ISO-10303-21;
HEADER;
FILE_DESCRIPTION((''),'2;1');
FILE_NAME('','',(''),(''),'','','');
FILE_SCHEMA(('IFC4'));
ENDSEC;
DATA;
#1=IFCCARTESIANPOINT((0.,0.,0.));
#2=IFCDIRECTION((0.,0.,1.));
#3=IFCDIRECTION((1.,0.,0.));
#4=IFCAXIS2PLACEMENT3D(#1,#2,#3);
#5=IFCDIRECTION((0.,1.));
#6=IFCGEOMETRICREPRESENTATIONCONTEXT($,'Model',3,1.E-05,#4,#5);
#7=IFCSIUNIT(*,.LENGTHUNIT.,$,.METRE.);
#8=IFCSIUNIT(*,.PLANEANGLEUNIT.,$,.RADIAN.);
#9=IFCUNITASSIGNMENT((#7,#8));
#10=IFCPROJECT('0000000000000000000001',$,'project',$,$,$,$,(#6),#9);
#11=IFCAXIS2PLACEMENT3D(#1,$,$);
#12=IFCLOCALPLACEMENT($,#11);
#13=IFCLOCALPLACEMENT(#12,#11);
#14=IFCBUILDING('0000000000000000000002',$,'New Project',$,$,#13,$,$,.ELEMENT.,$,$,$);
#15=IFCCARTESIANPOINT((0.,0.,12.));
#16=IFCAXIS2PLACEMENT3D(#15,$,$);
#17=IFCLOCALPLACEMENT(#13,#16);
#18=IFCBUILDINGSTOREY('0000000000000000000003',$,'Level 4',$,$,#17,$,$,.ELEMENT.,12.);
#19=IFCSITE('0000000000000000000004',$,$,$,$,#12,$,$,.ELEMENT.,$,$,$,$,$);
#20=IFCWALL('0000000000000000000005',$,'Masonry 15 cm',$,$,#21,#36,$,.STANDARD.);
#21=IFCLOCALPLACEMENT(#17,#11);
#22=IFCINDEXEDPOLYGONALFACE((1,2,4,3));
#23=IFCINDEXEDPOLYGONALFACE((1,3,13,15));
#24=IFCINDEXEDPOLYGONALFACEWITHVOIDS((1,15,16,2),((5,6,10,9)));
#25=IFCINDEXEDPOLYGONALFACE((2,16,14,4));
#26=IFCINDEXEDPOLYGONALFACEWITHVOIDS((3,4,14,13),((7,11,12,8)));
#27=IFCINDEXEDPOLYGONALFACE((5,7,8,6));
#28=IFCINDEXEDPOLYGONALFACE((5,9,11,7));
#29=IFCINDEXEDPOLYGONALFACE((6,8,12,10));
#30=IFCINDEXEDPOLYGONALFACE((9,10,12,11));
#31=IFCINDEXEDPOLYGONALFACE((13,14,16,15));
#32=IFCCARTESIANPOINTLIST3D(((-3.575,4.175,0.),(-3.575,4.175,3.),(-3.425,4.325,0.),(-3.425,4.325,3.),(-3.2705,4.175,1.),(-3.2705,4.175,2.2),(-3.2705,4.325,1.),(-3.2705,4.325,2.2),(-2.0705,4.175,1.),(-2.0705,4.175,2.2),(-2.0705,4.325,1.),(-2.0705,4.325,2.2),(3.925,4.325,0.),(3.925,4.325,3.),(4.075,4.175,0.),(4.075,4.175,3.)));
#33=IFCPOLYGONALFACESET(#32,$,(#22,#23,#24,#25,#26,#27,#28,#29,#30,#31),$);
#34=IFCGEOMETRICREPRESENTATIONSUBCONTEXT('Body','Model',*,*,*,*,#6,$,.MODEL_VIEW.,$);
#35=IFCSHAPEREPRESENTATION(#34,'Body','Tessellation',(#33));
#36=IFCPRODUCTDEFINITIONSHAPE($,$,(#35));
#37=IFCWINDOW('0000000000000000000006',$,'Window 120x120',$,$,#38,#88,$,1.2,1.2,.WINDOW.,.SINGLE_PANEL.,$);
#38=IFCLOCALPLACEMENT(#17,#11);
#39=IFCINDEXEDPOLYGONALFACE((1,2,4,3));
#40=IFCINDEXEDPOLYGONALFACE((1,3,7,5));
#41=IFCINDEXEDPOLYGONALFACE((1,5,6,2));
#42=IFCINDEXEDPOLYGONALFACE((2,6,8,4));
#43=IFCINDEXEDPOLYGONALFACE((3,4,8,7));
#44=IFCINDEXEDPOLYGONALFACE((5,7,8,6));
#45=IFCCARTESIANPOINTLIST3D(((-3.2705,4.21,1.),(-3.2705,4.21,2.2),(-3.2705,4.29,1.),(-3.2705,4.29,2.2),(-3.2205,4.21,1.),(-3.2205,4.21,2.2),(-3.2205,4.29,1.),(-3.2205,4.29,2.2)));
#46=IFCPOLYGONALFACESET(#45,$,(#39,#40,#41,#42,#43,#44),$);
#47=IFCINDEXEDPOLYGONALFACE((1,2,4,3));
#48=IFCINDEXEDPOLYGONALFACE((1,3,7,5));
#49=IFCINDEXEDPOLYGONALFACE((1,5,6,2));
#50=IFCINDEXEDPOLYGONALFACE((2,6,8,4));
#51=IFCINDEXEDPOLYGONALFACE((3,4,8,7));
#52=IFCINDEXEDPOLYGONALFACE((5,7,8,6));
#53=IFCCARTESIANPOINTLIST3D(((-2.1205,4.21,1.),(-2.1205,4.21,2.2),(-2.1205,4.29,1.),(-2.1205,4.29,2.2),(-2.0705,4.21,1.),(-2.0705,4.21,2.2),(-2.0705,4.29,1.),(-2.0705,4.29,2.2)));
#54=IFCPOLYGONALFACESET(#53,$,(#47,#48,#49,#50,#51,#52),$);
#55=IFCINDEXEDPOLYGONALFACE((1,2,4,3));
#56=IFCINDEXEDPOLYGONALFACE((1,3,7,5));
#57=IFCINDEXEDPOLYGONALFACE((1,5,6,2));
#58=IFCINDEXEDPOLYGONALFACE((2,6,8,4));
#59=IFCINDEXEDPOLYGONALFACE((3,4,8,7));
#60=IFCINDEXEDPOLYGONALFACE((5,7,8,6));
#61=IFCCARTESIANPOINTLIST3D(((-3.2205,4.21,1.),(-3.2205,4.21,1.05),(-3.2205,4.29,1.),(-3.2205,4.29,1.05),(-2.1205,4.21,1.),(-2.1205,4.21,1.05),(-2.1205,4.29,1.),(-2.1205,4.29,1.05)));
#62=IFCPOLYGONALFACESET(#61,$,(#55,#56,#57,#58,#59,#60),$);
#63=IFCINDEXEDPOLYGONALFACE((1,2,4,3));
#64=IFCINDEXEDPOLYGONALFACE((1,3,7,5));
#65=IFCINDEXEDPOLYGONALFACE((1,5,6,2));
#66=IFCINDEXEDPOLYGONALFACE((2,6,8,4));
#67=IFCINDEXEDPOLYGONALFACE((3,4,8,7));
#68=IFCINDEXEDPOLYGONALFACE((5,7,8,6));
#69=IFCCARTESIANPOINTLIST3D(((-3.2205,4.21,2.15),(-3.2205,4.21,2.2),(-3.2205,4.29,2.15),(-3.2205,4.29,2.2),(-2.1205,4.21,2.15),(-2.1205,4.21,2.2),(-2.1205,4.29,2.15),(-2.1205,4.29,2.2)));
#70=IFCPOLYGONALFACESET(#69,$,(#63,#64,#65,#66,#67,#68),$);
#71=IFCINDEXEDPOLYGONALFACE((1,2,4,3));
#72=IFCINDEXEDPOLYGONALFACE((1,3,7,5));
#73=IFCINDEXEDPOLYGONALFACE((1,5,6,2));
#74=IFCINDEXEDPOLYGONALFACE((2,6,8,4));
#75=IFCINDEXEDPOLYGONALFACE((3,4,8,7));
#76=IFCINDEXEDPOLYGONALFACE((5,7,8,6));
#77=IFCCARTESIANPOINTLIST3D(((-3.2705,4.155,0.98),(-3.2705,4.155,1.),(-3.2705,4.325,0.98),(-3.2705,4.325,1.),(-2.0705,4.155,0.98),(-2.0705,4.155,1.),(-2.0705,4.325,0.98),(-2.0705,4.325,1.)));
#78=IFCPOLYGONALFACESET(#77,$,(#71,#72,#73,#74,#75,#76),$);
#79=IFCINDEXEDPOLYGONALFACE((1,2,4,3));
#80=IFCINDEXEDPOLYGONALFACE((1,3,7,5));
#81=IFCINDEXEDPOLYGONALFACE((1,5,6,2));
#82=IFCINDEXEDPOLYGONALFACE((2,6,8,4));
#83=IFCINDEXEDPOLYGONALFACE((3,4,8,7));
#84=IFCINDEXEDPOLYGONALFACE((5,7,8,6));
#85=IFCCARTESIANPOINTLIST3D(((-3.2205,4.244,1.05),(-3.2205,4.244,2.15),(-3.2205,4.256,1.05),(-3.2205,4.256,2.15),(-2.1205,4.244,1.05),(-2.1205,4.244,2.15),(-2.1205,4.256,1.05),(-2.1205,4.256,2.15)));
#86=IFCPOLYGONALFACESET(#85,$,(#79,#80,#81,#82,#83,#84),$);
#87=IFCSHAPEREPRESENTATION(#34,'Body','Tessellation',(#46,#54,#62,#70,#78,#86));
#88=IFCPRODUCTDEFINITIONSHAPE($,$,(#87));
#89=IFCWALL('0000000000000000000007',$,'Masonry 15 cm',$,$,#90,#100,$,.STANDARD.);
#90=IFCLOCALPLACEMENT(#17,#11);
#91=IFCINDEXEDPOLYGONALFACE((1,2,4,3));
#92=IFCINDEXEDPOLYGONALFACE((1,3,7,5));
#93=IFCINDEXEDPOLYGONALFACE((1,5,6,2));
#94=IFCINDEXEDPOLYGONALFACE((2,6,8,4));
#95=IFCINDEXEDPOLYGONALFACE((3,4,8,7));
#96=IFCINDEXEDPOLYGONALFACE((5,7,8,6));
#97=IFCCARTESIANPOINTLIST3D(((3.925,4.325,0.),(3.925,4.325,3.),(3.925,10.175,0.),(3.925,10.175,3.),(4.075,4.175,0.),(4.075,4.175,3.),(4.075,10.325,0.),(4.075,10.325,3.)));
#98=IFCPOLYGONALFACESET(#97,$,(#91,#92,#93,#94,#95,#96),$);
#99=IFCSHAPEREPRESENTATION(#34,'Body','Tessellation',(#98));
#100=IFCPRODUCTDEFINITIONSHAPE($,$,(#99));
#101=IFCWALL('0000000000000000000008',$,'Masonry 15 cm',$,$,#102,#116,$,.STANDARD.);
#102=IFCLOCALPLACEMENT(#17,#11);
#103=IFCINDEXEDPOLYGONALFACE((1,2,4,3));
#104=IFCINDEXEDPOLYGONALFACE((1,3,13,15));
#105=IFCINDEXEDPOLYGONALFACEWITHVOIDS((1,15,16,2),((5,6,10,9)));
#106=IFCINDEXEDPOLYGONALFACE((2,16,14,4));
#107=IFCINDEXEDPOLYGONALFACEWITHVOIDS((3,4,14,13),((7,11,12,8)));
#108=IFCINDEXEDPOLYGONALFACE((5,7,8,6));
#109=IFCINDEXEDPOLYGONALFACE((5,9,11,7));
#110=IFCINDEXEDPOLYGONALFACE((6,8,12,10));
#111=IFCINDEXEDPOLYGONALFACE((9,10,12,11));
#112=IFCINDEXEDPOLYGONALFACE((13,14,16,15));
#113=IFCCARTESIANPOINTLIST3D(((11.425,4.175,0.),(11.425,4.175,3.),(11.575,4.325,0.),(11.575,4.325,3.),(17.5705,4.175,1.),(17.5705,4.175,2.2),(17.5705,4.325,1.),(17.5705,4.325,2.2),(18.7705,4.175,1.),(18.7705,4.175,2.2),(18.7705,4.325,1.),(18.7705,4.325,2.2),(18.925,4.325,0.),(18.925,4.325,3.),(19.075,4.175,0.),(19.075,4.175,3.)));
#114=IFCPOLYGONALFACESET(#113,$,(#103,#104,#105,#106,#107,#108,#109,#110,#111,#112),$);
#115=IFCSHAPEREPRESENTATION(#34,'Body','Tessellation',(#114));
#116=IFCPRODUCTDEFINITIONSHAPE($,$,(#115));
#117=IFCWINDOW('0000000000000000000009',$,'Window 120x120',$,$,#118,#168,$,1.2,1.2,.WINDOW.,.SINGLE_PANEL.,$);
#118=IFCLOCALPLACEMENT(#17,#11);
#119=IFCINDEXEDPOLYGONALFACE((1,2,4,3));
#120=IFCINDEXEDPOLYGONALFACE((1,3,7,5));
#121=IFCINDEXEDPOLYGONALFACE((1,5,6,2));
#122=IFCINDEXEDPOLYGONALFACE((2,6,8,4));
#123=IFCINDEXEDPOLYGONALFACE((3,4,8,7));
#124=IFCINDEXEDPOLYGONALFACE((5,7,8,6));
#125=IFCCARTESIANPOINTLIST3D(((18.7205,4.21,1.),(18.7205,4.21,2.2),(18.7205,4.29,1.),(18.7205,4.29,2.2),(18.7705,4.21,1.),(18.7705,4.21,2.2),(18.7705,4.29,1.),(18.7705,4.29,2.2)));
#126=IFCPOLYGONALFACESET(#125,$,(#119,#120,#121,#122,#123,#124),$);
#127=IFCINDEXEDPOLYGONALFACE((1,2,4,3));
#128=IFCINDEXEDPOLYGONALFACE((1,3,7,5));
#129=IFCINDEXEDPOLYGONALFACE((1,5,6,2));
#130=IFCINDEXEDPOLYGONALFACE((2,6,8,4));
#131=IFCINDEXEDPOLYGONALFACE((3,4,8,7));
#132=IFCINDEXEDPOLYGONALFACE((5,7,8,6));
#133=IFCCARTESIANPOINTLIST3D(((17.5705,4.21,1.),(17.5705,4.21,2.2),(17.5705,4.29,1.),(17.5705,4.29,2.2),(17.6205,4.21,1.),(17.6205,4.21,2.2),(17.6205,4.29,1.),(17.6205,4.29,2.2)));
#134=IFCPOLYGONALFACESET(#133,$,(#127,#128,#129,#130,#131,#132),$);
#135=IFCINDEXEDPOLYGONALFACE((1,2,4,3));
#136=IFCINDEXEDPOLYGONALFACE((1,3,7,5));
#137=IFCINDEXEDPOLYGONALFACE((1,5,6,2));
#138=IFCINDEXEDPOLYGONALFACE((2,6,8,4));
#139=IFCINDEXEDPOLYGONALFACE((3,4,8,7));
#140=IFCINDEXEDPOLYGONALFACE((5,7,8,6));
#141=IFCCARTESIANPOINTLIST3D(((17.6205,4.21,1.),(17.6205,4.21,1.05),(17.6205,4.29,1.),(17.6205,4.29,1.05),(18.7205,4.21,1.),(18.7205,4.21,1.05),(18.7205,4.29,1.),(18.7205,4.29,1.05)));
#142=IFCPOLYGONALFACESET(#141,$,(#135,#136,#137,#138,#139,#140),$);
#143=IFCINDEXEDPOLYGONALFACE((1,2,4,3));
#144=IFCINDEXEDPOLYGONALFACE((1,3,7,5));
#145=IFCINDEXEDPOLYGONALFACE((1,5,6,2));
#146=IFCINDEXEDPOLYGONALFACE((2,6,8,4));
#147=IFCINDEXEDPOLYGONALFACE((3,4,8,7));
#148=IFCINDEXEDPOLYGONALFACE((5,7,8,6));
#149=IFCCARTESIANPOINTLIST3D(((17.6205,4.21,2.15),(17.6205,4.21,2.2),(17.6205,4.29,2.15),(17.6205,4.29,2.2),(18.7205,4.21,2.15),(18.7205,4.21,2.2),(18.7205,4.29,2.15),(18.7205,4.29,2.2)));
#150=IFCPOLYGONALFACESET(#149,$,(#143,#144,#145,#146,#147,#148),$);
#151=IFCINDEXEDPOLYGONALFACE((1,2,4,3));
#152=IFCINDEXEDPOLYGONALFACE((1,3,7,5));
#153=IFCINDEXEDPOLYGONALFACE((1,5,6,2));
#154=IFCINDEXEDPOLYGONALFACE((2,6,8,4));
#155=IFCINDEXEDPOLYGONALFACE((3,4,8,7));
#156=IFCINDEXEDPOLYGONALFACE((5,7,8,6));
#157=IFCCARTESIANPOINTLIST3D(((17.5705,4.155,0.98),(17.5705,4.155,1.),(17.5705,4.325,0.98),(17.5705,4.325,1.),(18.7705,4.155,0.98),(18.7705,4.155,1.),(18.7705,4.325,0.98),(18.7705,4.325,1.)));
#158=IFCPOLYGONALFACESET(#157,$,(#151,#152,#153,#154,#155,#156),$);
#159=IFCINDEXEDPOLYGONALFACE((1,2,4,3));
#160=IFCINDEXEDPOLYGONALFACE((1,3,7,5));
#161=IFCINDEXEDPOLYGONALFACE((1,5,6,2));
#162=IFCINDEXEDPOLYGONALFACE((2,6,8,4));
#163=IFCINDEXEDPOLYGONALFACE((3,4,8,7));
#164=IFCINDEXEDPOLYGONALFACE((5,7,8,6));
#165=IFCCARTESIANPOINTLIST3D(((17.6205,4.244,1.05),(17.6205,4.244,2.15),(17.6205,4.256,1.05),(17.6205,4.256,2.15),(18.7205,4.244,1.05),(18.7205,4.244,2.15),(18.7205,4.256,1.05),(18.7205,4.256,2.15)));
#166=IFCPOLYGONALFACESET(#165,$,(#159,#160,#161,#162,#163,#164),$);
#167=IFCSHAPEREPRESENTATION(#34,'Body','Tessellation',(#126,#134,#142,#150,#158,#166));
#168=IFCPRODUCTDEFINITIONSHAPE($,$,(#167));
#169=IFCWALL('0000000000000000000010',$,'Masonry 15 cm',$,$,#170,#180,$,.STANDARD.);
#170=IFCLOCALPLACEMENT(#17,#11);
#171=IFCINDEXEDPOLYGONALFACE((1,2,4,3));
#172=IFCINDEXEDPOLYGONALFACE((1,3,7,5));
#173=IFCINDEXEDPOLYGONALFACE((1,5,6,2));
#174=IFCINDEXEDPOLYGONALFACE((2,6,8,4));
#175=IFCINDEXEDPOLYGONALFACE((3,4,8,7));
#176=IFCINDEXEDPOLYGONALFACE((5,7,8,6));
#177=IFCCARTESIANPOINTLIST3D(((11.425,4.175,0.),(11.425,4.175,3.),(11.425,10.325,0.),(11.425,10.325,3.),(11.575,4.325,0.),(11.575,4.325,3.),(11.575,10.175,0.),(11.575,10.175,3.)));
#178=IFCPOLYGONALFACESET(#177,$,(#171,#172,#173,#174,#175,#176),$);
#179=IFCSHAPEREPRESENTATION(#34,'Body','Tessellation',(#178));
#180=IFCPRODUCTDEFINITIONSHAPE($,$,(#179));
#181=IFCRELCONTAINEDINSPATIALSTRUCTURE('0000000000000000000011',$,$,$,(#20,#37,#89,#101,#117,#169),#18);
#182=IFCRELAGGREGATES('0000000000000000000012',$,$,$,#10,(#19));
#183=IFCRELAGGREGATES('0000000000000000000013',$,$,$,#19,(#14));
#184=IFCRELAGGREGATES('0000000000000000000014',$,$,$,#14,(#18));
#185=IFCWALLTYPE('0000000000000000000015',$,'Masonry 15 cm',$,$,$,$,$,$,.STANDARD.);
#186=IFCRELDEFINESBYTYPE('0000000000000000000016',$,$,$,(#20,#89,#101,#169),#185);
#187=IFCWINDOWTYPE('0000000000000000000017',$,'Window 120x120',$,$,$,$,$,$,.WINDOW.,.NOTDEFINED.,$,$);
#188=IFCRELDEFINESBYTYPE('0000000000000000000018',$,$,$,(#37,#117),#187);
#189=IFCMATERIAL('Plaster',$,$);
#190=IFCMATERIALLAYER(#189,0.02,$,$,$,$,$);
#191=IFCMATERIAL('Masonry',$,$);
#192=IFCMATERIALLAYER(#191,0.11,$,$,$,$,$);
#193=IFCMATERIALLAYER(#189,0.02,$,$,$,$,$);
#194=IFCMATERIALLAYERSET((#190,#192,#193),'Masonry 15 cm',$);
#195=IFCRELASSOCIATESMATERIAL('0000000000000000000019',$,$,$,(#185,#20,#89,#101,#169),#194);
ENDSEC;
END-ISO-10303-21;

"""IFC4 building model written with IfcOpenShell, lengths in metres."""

from ifc_helpers import new_model, si_unit, direction, frame, frame_2d, origin, origin_with_axes, place, context, subcontext, project, spatial, polyline, rectangle, outline, extrude, material, layer, layer_set, layer_usage, type_object, element, fill, save


model = new_model("IFC4")

# Units and contexts
model_context = context("Model", 3, precision=1e-05, world=origin_with_axes(), true_north=direction((0.0, 1.0)))
body_context = subcontext(model_context, "Body", "Model", "MODEL_VIEW")
ifc_project = project(units=[si_unit("LENGTHUNIT", "METRE"), si_unit("PLANEANGLEUNIT", "RADIAN")], contexts=[model_context])

# Site, building, storey
site_placement = place(None, origin())
site = spatial("IfcSite", under=ifc_project, at=site_placement, CompositionType="ELEMENT")
building_placement = place(site_placement, origin())
building = spatial("IfcBuilding", under=site, at=building_placement, Name="New Project", CompositionType="ELEMENT")
storey_placement = place(building_placement, frame((0.0, 0.0, 12.0)))
storey = spatial("IfcBuildingStorey", under=building, at=storey_placement, Name="Level 4", CompositionType="ELEMENT", Elevation=12.0)

# Wall, opening, window
ifc_material_1 = material(Name="Plaster")
ifc_layer_1 = layer(ifc_material_1, 0.02)
ifc_material_2 = material(Name="Masonry")
ifc_layer_2 = layer(ifc_material_2, 0.11)
ifc_layer_3 = layer(ifc_material_1, 0.02)
ifc_layer_set_1 = layer_set([ifc_layer_1, ifc_layer_2, ifc_layer_3], Name="Masonry 15 cm")
ifc_layer_usage_1 = layer_usage(ifc_layer_set_1, "AXIS2", "NEGATIVE", 0.075)
wall_type_1 = type_object("IfcWallType", Name="Masonry 15 cm", PredefinedType="STANDARD", material=ifc_layer_set_1)
wall_1_placement = place(storey_placement, frame((4.0, 4.25, 0.0), z_axis=(0.0, 0.0, 1.0), x_axis=(-1.0, 0.0, 0.0)))
wall_1 = element("IfcWall", 1, at=wall_1_placement, inside=storey, type_object=wall_type_1, material=ifc_layer_usage_1, Name="Masonry 15 cm", PredefinedType="STANDARD", context=body_context, shape_type="SweptSolid", body=[
    extrude(outline(polyline([(0.075, -0.075), (7.425, -0.075), (7.575, 0.075), (-0.075, 0.075), (0.075, -0.075)])), origin(), (0.0, 0.0, 1.0), 3.0),
])
opening_1_placement = place(wall_1_placement, frame((6.0705, 0.0, 1.0)))
opening_1 = element("IfcOpeningElement", 2, at=opening_1_placement, cuts=wall_1, PredefinedType="OPENING", context=body_context, shape_type="SweptSolid", body=[
    extrude(rectangle(XDim=1.2, YDim=0.25, at=frame_2d((0.6, 0.0))), origin(), (0.0, 0.0, 1.0), 1.2),
])
window_type = type_object("IfcWindowType", Name="Window 120x120", PartitioningType="NOTDEFINED", PredefinedType="WINDOW")
window_1_placement = place(opening_1_placement, origin())
window_1 = element("IfcWindow", 3, at=window_1_placement, inside=storey, type_object=window_type, Name="Window 120x120", OverallHeight=1.2, OverallWidth=1.2, PartitioningType="SINGLE_PANEL", PredefinedType="WINDOW", context=body_context, shape_type="SweptSolid", body=[
    extrude(outline(polyline([(1.2, 0.04), (1.15, 0.04), (1.15, -0.04), (1.2, -0.04), (1.2, 0.04)])), origin(), (0.0, 0.0, 1.0), 1.2),
    extrude(outline(polyline([(0.05, 0.04), (0.0, 0.04), (0.0, -0.04), (0.05, -0.04), (0.05, 0.04)])), origin(), (0.0, 0.0, 1.0), 1.2),
    extrude(outline(polyline([(1.15, 0.04), (0.05, 0.04), (0.05, -0.04), (1.15, -0.04), (1.15, 0.04)])), origin(), (0.0, 0.0, 1.0), 0.05),
    extrude(outline(polyline([(1.15, 0.04), (0.05, 0.04), (0.05, -0.04), (1.15, -0.04), (1.15, 0.04)])), frame((0.0, 0.0, 1.15)), (0.0, 0.0, 1.0), 0.05),
    extrude(outline(polyline([(1.2, 0.095), (0.0, 0.095), (0.0, -0.075), (1.2, -0.075), (1.2, 0.095)])), frame((0.0, 0.0, -0.02)), (0.0, 0.0, 1.0), 0.02),
    extrude(outline(polyline([(1.15, 0.006), (0.05, 0.006), (0.05, -0.006), (1.15, -0.006), (1.15, 0.006)])), frame((0.0, 0.0, 0.05)), (0.0, 0.0, 1.0), 1.1),
])
fill(opening_1, window_1)

# Wall
wall_2_placement = place(storey_placement, frame((4.0, 10.25, 0.0), z_axis=(0.0, 0.0, 1.0), x_axis=(0.0, -1.0, 0.0)))
element("IfcWall", 4, at=wall_2_placement, inside=storey, type_object=wall_type_1, material=ifc_layer_usage_1, Name="Masonry 15 cm", PredefinedType="STANDARD", context=body_context, shape_type="SweptSolid", body=[
    extrude(outline(polyline([(0.075, -0.075), (5.925, -0.075), (6.075, 0.075), (-0.075, 0.075), (0.075, -0.075)])), origin(), (0.0, 0.0, 1.0), 3.0),
])

# Wall, opening, window
wall_3_placement = place(storey_placement, frame((19.0, 4.25, 0.0), z_axis=(0.0, 0.0, 1.0), x_axis=(-1.0, 0.0, 0.0)))
wall_3 = element("IfcWall", 5, at=wall_3_placement, inside=storey, type_object=wall_type_1, material=ifc_layer_usage_1, Name="Masonry 15 cm", PredefinedType="STANDARD", context=body_context, shape_type="SweptSolid", body=[
    extrude(outline(polyline([(0.075, -0.075), (7.425, -0.075), (7.575, 0.075), (-0.075, 0.075), (0.075, -0.075)])), origin(), (0.0, 0.0, 1.0), 3.0),
])
opening_2_placement = place(wall_3_placement, frame((0.2295, 0.0, 1.0)))
opening_2 = element("IfcOpeningElement", 6, at=opening_2_placement, cuts=wall_3, PredefinedType="OPENING", context=body_context, shape_type="SweptSolid", body=[
    extrude(rectangle(XDim=1.2, YDim=0.25, at=frame_2d((0.6, 0.0))), origin(), (0.0, 0.0, 1.0), 1.2),
])
window_2_placement = place(opening_2_placement, origin())
window_2 = element("IfcWindow", 7, at=window_2_placement, inside=storey, type_object=window_type, Name="Window 120x120", OverallHeight=1.2, OverallWidth=1.2, PartitioningType="SINGLE_PANEL", PredefinedType="WINDOW", context=body_context, shape_type="SweptSolid", body=[
    extrude(outline(polyline([(0.0, -0.04), (0.05, -0.04), (0.05, 0.04), (0.0, 0.04), (0.0, -0.04)])), origin(), (0.0, 0.0, 1.0), 1.2),
    extrude(outline(polyline([(1.15, -0.04), (1.2, -0.04), (1.2, 0.04), (1.15, 0.04), (1.15, -0.04)])), origin(), (0.0, 0.0, 1.0), 1.2),
    extrude(outline(polyline([(0.05, -0.04), (1.15, -0.04), (1.15, 0.04), (0.05, 0.04), (0.05, -0.04)])), origin(), (0.0, 0.0, 1.0), 0.05),
    extrude(outline(polyline([(0.05, -0.04), (1.15, -0.04), (1.15, 0.04), (0.05, 0.04), (0.05, -0.04)])), frame((0.0, 0.0, 1.15)), (0.0, 0.0, 1.0), 0.05),
    extrude(outline(polyline([(0.0, -0.075), (1.2, -0.075), (1.2, 0.095), (0.0, 0.095), (0.0, -0.075)])), frame((0.0, 0.0, -0.02)), (0.0, 0.0, 1.0), 0.02),
    extrude(outline(polyline([(0.05, -0.006), (1.15, -0.006), (1.15, 0.006), (0.05, 0.006), (0.05, -0.006)])), frame((0.0, 0.0, 0.05)), (0.0, 0.0, 1.0), 1.1),
])
fill(opening_2, window_2)

# Wall
wall_4_placement = place(storey_placement, frame((11.5, 4.25, 0.0), z_axis=(0.0, 0.0, 1.0), x_axis=(0.0, 1.0, 0.0)))
element("IfcWall", 8, at=wall_4_placement, inside=storey, type_object=wall_type_1, material=ifc_layer_usage_1, Name="Masonry 15 cm", PredefinedType="STANDARD", context=body_context, shape_type="SweptSolid", body=[
    extrude(outline(polyline([(0.075, -0.075), (5.925, -0.075), (6.075, 0.075), (-0.075, 0.075), (0.075, -0.075)])), origin(), (0.0, 0.0, 1.0), 3.0),
])

save(model, "model.ifc")
